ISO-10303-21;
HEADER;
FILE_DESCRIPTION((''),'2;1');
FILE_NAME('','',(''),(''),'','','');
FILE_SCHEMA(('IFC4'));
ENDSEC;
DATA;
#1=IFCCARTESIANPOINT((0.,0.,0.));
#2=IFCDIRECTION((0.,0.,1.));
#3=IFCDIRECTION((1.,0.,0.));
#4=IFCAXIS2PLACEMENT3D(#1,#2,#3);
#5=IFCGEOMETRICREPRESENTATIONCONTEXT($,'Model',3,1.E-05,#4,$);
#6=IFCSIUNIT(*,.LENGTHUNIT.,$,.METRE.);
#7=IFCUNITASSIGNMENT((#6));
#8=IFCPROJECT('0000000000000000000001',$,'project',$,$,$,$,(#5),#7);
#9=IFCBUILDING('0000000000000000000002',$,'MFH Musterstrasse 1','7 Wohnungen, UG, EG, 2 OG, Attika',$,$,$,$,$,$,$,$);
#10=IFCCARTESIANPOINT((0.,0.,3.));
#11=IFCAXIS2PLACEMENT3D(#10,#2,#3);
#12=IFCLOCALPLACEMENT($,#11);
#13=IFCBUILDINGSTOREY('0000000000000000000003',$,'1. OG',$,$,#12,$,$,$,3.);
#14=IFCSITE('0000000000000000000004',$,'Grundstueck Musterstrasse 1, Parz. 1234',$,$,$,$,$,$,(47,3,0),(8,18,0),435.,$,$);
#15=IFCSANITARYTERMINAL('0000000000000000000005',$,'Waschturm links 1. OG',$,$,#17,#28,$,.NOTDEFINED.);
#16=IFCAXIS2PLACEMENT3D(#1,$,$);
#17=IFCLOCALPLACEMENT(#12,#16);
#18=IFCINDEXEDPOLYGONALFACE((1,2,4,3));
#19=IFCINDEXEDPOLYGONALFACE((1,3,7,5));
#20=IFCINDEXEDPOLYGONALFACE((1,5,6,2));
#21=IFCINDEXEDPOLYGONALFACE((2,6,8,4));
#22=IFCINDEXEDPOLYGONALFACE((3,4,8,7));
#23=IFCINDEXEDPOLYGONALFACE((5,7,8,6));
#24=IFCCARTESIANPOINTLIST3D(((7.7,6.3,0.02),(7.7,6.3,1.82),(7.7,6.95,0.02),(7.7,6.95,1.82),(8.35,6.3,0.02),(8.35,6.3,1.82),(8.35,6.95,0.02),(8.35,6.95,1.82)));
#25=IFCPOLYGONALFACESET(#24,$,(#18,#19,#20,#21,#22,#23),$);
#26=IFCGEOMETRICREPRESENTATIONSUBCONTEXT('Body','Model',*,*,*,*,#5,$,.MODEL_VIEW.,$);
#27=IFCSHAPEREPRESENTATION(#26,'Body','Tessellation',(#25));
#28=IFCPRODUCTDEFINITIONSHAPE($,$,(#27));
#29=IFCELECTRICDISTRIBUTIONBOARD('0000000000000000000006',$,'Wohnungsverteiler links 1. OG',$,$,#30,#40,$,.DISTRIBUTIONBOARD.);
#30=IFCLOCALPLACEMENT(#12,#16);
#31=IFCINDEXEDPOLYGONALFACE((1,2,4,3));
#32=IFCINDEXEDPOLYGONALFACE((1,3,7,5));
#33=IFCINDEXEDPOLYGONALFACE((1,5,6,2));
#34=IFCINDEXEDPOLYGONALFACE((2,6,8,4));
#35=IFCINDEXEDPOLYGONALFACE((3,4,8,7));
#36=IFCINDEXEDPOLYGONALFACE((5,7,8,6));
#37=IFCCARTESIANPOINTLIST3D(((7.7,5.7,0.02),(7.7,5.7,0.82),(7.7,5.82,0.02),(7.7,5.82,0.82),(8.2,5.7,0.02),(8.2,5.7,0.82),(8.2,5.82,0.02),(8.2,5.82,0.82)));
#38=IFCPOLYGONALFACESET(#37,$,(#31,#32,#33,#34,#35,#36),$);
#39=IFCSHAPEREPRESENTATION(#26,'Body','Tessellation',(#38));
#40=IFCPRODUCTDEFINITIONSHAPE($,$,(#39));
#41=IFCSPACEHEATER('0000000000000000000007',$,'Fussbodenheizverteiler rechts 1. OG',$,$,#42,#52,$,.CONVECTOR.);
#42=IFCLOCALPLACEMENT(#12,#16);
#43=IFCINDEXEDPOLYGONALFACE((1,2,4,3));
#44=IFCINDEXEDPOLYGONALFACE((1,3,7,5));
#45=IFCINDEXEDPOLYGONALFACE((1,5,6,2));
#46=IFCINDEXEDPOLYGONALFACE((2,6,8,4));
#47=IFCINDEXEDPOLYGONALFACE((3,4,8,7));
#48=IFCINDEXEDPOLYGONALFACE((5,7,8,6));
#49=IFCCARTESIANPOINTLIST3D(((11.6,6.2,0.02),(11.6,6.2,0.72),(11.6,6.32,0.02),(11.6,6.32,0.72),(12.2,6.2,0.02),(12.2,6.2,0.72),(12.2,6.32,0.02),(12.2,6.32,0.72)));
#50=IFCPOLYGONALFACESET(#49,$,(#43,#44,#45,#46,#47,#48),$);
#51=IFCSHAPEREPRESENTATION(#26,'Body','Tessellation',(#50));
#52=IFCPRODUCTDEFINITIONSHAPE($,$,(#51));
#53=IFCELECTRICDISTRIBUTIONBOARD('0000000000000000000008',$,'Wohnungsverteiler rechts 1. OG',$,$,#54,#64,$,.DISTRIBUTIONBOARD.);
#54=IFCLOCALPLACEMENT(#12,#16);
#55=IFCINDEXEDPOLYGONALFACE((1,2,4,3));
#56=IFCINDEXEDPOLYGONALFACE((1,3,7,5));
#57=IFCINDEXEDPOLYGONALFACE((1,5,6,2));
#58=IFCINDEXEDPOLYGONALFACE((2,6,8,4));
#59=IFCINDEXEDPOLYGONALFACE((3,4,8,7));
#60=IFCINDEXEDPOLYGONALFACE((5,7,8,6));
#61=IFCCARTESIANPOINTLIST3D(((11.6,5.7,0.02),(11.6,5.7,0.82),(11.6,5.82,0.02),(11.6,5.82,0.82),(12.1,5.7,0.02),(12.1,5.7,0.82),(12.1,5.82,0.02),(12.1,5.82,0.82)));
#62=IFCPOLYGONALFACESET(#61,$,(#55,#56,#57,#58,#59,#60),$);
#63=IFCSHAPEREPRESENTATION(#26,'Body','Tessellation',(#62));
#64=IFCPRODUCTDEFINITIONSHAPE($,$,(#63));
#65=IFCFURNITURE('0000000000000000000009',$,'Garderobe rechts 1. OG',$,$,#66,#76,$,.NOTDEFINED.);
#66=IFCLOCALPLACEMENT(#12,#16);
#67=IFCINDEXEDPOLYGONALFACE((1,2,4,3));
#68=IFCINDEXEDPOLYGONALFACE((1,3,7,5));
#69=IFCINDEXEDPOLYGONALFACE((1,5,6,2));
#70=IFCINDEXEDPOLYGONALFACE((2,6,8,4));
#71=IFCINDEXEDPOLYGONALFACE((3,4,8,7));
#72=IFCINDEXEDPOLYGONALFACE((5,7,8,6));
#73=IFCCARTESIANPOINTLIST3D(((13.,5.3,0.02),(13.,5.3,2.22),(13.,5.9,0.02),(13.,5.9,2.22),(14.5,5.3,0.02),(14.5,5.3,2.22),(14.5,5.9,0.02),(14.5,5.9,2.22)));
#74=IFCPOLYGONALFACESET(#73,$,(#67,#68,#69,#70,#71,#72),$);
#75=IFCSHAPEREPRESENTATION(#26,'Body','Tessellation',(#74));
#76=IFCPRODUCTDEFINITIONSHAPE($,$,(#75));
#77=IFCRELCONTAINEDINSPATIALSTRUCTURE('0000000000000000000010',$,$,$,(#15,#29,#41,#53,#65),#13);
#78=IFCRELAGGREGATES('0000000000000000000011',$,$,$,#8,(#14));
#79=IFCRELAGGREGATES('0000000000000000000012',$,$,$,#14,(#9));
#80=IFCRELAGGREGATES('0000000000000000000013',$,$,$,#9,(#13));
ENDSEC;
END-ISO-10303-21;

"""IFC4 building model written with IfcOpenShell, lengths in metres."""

from ifc_helpers import new_model, si_unit, frame, frame_2d, origin_with_axes, place, context, subcontext, project, spatial, rectangle, extrude, element, save


model = new_model("IFC4")

# Units and contexts
model_context = context("Model", 3, precision=1e-05, world=origin_with_axes())
body_context = subcontext(model_context, "Body", "Model", "MODEL_VIEW")
ifc_project = project(units=[si_unit("LENGTHUNIT", "METRE")], contexts=[model_context])

# Site, building, storey
site = spatial("IfcSite", under=ifc_project, Name="Grundstueck Musterstrasse 1, Parz. 1234", RefLatitude=(47, 3, 0), RefLongitude=(8, 18, 0), RefElevation=435.0)
building = spatial("IfcBuilding", under=site, Name="MFH Musterstrasse 1", Description="7 Wohnungen, UG, EG, 2 OG, Attika")
storey_placement = place(None, frame((0.0, 0.0, 3.0), z_axis=(0.0, 0.0, 1.0), x_axis=(1.0, 0.0, 0.0)))
storey = spatial("IfcBuildingStorey", under=building, at=storey_placement, Name="1. OG", Elevation=3.0)

# Sanitary terminal
sanitary_terminal_placement = place(storey_placement, frame((7.7, 6.3, 0.02), z_axis=(0.0, 0.0, 1.0), x_axis=(1.0, 0.0, 0.0)))
element("IfcSanitaryTerminal", 1, at=sanitary_terminal_placement, inside=storey, Name="Waschturm links 1. OG", PredefinedType="NOTDEFINED", context=body_context, shape_type="SweptSolid", body=[
    extrude(rectangle(XDim=0.65, YDim=0.65, at=frame_2d((0.325, 0.325))), origin_with_axes(), (0.0, 0.0, 1.0), 1.8),
])

# Electric distribution board
electric_distribution_board_1_placement = place(storey_placement, frame((7.7, 5.7, 0.02), z_axis=(0.0, 0.0, 1.0), x_axis=(1.0, 0.0, 0.0)))
element("IfcElectricDistributionBoard", 2, at=electric_distribution_board_1_placement, inside=storey, Name="Wohnungsverteiler links 1. OG", PredefinedType="DISTRIBUTIONBOARD", context=body_context, shape_type="SweptSolid", body=[
    extrude(rectangle(XDim=0.5, YDim=0.12, at=frame_2d((0.25, 0.06))), origin_with_axes(), (0.0, 0.0, 1.0), 0.8),
])

# Space heater
space_heater_placement = place(storey_placement, frame((11.6, 6.2, 0.02), z_axis=(0.0, 0.0, 1.0), x_axis=(1.0, 0.0, 0.0)))
element("IfcSpaceHeater", 3, at=space_heater_placement, inside=storey, Name="Fussbodenheizverteiler rechts 1. OG", PredefinedType="CONVECTOR", context=body_context, shape_type="SweptSolid", body=[
    extrude(rectangle(XDim=0.6, YDim=0.12, at=frame_2d((0.3, 0.06))), origin_with_axes(), (0.0, 0.0, 1.0), 0.7),
])

# Electric distribution board
electric_distribution_board_2_placement = place(storey_placement, frame((11.6, 5.7, 0.02), z_axis=(0.0, 0.0, 1.0), x_axis=(1.0, 0.0, 0.0)))
element("IfcElectricDistributionBoard", 4, at=electric_distribution_board_2_placement, inside=storey, Name="Wohnungsverteiler rechts 1. OG", PredefinedType="DISTRIBUTIONBOARD", context=body_context, shape_type="SweptSolid", body=[
    extrude(rectangle(XDim=0.5, YDim=0.12, at=frame_2d((0.25, 0.06))), origin_with_axes(), (0.0, 0.0, 1.0), 0.8),
])

# Furniture
furniture_placement = place(storey_placement, frame((13.0, 5.3, 0.02), z_axis=(0.0, 0.0, 1.0), x_axis=(1.0, 0.0, 0.0)))
element("IfcFurniture", 5, at=furniture_placement, inside=storey, Name="Garderobe rechts 1. OG", PredefinedType="NOTDEFINED", context=body_context, shape_type="SweptSolid", body=[
    extrude(rectangle(XDim=1.5, YDim=0.6, at=frame_2d((0.75, 0.3))), origin_with_axes(), (0.0, 0.0, 1.0), 2.2),
])

save(model, "model.ifc")
